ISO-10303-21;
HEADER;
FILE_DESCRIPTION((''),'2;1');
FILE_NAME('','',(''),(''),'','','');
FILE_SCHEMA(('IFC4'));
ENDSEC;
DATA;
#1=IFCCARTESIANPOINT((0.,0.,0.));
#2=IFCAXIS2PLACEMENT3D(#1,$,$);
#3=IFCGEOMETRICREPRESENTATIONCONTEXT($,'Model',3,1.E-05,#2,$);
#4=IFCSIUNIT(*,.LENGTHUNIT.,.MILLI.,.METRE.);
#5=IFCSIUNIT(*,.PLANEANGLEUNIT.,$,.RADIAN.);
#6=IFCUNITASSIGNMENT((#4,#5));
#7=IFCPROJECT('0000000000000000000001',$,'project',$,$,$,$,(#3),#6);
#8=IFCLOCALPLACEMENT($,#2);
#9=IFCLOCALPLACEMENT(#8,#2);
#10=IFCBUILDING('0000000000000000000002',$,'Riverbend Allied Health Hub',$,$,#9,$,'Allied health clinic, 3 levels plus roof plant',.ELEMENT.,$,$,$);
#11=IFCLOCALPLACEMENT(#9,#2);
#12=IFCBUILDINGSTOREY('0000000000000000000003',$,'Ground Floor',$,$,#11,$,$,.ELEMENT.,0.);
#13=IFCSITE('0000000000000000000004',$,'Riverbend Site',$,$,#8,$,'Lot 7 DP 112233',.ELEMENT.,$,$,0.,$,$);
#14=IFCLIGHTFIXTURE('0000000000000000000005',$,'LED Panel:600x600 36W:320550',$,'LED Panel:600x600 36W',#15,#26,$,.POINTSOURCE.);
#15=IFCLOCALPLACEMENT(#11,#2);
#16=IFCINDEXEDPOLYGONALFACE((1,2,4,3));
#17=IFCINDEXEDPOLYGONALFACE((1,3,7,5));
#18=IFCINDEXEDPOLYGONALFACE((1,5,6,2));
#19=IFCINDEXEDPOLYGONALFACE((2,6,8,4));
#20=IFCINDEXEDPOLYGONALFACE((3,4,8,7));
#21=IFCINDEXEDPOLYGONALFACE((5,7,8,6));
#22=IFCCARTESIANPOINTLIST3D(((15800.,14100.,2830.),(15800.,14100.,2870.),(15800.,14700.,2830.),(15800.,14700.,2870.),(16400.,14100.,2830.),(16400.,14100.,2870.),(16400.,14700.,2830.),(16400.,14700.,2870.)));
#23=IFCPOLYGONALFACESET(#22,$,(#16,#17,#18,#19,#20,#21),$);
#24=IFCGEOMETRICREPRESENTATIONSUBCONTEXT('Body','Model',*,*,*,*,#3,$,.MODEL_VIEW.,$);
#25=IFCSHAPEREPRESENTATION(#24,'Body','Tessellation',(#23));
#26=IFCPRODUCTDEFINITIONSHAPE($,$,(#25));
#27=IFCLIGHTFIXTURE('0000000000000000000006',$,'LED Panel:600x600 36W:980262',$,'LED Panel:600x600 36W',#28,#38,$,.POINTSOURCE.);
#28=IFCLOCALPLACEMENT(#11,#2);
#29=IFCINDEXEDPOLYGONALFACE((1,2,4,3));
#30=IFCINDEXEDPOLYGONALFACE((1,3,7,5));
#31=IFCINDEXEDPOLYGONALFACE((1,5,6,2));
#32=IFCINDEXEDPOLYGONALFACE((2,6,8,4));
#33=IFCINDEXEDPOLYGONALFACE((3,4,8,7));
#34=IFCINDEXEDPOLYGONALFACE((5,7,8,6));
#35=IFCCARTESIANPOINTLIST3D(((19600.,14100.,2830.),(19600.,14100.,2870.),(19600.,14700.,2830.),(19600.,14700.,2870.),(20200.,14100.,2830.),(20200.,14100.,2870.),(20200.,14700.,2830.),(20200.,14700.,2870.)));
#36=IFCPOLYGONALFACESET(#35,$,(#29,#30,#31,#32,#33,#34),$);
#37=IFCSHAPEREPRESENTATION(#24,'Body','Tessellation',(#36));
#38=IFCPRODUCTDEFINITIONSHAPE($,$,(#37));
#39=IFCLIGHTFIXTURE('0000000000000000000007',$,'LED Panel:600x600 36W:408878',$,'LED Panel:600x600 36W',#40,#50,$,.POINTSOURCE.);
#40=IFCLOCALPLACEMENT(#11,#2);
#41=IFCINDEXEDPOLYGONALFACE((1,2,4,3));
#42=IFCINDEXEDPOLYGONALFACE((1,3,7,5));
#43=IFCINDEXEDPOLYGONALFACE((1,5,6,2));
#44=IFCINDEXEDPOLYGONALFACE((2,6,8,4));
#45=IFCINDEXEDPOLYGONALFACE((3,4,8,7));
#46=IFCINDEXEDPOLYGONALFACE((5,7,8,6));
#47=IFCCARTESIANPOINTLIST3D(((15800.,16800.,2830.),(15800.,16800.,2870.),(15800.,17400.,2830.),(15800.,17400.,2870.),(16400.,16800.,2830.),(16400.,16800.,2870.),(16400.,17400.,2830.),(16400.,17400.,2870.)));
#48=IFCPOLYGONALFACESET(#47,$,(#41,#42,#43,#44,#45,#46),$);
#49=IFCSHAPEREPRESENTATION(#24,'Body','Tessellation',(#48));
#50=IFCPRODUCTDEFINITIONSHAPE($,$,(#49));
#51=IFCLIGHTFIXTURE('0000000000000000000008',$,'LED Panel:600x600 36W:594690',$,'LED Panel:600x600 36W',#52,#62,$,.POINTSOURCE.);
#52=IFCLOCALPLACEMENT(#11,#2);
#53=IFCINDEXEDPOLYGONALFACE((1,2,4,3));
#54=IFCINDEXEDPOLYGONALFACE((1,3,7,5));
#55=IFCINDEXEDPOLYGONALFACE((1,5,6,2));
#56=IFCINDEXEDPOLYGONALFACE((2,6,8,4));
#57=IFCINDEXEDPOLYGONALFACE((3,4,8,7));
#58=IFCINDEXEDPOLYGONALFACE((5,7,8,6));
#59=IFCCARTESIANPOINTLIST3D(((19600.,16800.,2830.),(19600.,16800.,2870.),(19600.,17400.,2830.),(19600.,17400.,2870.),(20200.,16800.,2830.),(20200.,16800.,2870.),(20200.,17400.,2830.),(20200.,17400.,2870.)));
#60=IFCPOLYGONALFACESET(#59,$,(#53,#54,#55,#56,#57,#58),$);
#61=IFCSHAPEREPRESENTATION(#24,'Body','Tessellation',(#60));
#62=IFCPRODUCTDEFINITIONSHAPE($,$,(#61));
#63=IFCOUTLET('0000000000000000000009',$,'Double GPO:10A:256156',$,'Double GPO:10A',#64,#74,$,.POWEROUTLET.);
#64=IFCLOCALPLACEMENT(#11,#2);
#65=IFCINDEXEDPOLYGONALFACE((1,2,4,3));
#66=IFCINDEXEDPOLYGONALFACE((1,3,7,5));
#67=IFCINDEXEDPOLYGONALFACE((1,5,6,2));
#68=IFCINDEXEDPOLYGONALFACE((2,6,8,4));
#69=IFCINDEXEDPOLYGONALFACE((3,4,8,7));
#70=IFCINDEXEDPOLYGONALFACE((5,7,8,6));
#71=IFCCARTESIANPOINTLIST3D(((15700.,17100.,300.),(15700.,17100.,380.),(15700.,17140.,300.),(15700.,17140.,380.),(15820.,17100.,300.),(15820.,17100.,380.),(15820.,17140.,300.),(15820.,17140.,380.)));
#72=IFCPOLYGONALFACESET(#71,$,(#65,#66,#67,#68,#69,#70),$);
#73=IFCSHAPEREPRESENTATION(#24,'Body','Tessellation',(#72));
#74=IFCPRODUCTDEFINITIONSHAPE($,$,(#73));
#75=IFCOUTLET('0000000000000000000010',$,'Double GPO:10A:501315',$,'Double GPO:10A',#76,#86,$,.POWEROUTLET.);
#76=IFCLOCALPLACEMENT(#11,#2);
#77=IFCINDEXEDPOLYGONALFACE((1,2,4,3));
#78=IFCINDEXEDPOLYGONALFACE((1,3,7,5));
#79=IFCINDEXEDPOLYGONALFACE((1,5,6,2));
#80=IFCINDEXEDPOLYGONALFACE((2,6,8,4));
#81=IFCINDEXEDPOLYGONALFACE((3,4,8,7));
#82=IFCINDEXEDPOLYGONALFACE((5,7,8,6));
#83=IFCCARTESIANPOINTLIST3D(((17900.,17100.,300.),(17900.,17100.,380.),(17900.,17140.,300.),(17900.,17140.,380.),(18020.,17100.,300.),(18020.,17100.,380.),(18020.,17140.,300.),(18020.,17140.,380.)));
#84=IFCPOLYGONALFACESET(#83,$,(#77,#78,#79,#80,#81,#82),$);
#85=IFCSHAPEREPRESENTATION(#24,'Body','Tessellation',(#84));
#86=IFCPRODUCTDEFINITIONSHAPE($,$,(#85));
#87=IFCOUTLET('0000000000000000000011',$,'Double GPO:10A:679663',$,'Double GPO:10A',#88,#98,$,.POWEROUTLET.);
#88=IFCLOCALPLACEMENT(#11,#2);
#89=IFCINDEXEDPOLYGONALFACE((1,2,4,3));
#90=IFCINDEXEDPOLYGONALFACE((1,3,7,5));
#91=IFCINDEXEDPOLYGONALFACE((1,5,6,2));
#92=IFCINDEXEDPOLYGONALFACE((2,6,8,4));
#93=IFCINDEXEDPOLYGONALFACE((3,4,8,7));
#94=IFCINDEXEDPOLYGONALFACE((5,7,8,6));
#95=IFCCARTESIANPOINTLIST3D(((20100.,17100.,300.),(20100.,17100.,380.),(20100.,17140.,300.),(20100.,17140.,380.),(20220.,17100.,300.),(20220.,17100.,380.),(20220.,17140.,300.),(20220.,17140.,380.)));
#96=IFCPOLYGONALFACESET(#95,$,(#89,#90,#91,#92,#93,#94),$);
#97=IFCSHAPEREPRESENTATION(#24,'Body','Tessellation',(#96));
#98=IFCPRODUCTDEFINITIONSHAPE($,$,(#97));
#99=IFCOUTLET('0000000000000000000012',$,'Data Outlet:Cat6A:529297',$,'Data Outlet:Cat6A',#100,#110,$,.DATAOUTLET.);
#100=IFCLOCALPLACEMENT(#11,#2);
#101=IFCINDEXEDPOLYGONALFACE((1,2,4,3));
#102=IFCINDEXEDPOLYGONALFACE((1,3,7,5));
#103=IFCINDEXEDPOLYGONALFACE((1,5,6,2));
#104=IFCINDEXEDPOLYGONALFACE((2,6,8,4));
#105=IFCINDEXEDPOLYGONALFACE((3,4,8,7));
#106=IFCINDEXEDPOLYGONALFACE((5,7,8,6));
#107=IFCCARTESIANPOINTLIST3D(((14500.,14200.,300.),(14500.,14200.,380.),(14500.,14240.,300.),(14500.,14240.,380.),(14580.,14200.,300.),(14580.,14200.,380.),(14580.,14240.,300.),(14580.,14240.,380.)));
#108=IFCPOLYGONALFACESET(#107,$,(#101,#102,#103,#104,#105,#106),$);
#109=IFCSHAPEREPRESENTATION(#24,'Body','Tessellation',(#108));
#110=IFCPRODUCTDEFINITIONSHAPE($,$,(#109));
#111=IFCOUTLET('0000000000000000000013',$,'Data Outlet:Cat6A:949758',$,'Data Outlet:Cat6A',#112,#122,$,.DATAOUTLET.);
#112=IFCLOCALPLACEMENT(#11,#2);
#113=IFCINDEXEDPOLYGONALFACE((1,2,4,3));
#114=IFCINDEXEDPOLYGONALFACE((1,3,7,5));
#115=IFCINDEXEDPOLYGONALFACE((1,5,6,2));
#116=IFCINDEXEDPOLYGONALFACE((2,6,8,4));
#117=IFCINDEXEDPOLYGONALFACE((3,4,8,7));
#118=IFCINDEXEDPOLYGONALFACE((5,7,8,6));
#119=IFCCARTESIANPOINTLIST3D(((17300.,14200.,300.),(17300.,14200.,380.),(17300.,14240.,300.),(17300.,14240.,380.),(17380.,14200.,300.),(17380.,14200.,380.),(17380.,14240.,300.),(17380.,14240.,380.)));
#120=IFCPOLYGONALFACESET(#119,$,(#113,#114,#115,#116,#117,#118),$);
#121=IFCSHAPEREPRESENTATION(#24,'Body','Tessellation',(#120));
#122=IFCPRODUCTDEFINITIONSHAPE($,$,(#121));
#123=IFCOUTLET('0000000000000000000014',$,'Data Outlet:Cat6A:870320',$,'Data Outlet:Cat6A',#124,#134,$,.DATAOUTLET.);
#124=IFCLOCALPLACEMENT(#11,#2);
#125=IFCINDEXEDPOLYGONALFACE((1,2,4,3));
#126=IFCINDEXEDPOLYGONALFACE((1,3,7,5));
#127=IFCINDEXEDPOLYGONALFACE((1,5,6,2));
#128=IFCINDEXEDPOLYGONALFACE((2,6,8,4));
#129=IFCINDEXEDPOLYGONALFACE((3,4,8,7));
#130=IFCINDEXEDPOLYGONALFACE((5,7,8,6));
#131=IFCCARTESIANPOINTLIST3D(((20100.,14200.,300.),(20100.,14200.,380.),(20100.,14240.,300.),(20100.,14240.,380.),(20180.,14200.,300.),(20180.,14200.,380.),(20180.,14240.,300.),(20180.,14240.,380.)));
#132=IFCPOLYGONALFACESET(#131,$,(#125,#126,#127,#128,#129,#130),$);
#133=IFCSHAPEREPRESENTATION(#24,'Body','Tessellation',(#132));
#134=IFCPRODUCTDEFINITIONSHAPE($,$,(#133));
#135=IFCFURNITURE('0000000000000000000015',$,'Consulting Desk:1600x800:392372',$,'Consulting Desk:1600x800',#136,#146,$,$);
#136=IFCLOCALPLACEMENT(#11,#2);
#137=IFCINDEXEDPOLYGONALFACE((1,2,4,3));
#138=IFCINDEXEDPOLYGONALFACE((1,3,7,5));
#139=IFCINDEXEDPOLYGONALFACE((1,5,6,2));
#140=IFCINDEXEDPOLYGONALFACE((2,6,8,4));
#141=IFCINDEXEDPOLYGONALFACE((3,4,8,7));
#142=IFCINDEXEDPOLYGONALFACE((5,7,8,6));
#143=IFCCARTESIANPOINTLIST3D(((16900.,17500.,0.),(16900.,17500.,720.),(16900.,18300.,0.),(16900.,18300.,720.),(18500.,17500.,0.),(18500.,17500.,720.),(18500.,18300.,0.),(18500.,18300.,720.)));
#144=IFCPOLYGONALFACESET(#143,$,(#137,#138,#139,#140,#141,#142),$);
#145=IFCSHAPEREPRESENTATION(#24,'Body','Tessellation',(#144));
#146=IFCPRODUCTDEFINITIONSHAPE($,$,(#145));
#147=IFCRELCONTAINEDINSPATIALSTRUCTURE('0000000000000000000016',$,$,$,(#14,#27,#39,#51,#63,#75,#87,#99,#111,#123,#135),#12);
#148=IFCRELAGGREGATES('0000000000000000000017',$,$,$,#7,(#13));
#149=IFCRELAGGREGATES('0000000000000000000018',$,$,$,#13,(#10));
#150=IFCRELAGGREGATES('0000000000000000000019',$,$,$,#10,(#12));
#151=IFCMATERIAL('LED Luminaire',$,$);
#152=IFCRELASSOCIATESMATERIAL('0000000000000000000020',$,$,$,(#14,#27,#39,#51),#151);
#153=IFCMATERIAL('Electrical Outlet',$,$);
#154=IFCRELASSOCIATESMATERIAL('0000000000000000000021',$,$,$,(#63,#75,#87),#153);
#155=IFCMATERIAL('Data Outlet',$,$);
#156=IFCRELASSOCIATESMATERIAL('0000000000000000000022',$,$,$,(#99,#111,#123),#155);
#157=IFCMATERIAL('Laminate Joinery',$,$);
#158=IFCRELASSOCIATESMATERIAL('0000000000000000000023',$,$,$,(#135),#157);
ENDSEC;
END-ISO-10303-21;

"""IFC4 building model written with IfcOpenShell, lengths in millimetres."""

from ifc_helpers import new_model, si_unit, frame, frame_2d, origin, place, context, subcontext, project, spatial, rectangle, extrude, material, element, save


model = new_model("IFC4")

# Units and contexts
model_context = context("Model", 3, precision=1e-05, world=origin())
body_context = subcontext(model_context, "Body", "Model", "MODEL_VIEW")
ifc_project = project(units=[si_unit("LENGTHUNIT", "METRE", prefix="MILLI"), si_unit("PLANEANGLEUNIT", "RADIAN")], contexts=[model_context])

# Site, building, storey
site_placement = place(None, origin())
site = spatial("IfcSite", under=ifc_project, at=site_placement, Name="Riverbend Site", LongName="Lot 7 DP 112233", CompositionType="ELEMENT", RefElevation=0.0)
building_placement = place(site_placement, origin())
building = spatial("IfcBuilding", under=site, at=building_placement, Name="Riverbend Allied Health Hub", LongName="Allied health clinic, 3 levels plus roof plant", CompositionType="ELEMENT")
storey_placement = place(building_placement, origin())
storey = spatial("IfcBuildingStorey", under=building, at=storey_placement, Name="Ground Floor", CompositionType="ELEMENT", Elevation=0.0)

# Light fixtures
ifc_material_1 = material(Name="LED Luminaire")
for number, where, name in (
    (1, (15800.0, 14100.0, 2830.0), "LED Panel:600x600 36W:320550"),
    (2, (19600.0, 14100.0, 2830.0), "LED Panel:600x600 36W:980262"),
    (3, (15800.0, 16800.0, 2830.0), "LED Panel:600x600 36W:408878"),
    (4, (19600.0, 16800.0, 2830.0), "LED Panel:600x600 36W:594690"),
):
    element("IfcLightFixture", number, at=place(storey_placement, frame(where)), inside=storey, material=ifc_material_1, Name=name, ObjectType="LED Panel:600x600 36W", PredefinedType="POINTSOURCE", context=body_context, shape_type="SweptSolid", body=[
        extrude(rectangle(XDim=600.0, YDim=600.0, at=frame_2d((300.0, 300.0))), origin(), (0.0, 0.0, 1.0), 40.0),
    ])

# Outlets
ifc_material_2 = material(Name="Electrical Outlet")
for number, where, name in (
    (5, (15700.0, 17100.0, 300.0), "Double GPO:10A:256156"),
    (6, (17900.0, 17100.0, 300.0), "Double GPO:10A:501315"),
    (7, (20100.0, 17100.0, 300.0), "Double GPO:10A:679663"),
):
    element("IfcOutlet", number, at=place(storey_placement, frame(where)), inside=storey, material=ifc_material_2, Name=name, ObjectType="Double GPO:10A", PredefinedType="POWEROUTLET", context=body_context, shape_type="SweptSolid", body=[
        extrude(rectangle(XDim=120.0, YDim=40.0, at=frame_2d((60.0, 20.0))), origin(), (0.0, 0.0, 1.0), 80.0),
    ])
ifc_material_3 = material(Name="Data Outlet")
for number, where, name in (
    (8, (14500.0, 14200.0, 300.0), "Data Outlet:Cat6A:529297"),
    (9, (17300.0, 14200.0, 300.0), "Data Outlet:Cat6A:949758"),
    (10, (20100.0, 14200.0, 300.0), "Data Outlet:Cat6A:870320"),
):
    element("IfcOutlet", number, at=place(storey_placement, frame(where)), inside=storey, material=ifc_material_3, Name=name, ObjectType="Data Outlet:Cat6A", PredefinedType="DATAOUTLET", context=body_context, shape_type="SweptSolid", body=[
        extrude(rectangle(XDim=80.0, YDim=40.0, at=frame_2d((40.0, 20.0))), origin(), (0.0, 0.0, 1.0), 80.0),
    ])

# Furniture
ifc_material_4 = material(Name="Laminate Joinery")
furniture_placement = place(storey_placement, frame((16900.0, 17500.0, 0.0)))
element("IfcFurniture", 11, at=furniture_placement, inside=storey, material=ifc_material_4, Name="Consulting Desk:1600x800:392372", ObjectType="Consulting Desk:1600x800", context=body_context, shape_type="SweptSolid", body=[
    extrude(rectangle(XDim=1600.0, YDim=800.0, at=frame_2d((800.0, 400.0))), origin(), (0.0, 0.0, 1.0), 720.0),
])

save(model, "model.ifc")
